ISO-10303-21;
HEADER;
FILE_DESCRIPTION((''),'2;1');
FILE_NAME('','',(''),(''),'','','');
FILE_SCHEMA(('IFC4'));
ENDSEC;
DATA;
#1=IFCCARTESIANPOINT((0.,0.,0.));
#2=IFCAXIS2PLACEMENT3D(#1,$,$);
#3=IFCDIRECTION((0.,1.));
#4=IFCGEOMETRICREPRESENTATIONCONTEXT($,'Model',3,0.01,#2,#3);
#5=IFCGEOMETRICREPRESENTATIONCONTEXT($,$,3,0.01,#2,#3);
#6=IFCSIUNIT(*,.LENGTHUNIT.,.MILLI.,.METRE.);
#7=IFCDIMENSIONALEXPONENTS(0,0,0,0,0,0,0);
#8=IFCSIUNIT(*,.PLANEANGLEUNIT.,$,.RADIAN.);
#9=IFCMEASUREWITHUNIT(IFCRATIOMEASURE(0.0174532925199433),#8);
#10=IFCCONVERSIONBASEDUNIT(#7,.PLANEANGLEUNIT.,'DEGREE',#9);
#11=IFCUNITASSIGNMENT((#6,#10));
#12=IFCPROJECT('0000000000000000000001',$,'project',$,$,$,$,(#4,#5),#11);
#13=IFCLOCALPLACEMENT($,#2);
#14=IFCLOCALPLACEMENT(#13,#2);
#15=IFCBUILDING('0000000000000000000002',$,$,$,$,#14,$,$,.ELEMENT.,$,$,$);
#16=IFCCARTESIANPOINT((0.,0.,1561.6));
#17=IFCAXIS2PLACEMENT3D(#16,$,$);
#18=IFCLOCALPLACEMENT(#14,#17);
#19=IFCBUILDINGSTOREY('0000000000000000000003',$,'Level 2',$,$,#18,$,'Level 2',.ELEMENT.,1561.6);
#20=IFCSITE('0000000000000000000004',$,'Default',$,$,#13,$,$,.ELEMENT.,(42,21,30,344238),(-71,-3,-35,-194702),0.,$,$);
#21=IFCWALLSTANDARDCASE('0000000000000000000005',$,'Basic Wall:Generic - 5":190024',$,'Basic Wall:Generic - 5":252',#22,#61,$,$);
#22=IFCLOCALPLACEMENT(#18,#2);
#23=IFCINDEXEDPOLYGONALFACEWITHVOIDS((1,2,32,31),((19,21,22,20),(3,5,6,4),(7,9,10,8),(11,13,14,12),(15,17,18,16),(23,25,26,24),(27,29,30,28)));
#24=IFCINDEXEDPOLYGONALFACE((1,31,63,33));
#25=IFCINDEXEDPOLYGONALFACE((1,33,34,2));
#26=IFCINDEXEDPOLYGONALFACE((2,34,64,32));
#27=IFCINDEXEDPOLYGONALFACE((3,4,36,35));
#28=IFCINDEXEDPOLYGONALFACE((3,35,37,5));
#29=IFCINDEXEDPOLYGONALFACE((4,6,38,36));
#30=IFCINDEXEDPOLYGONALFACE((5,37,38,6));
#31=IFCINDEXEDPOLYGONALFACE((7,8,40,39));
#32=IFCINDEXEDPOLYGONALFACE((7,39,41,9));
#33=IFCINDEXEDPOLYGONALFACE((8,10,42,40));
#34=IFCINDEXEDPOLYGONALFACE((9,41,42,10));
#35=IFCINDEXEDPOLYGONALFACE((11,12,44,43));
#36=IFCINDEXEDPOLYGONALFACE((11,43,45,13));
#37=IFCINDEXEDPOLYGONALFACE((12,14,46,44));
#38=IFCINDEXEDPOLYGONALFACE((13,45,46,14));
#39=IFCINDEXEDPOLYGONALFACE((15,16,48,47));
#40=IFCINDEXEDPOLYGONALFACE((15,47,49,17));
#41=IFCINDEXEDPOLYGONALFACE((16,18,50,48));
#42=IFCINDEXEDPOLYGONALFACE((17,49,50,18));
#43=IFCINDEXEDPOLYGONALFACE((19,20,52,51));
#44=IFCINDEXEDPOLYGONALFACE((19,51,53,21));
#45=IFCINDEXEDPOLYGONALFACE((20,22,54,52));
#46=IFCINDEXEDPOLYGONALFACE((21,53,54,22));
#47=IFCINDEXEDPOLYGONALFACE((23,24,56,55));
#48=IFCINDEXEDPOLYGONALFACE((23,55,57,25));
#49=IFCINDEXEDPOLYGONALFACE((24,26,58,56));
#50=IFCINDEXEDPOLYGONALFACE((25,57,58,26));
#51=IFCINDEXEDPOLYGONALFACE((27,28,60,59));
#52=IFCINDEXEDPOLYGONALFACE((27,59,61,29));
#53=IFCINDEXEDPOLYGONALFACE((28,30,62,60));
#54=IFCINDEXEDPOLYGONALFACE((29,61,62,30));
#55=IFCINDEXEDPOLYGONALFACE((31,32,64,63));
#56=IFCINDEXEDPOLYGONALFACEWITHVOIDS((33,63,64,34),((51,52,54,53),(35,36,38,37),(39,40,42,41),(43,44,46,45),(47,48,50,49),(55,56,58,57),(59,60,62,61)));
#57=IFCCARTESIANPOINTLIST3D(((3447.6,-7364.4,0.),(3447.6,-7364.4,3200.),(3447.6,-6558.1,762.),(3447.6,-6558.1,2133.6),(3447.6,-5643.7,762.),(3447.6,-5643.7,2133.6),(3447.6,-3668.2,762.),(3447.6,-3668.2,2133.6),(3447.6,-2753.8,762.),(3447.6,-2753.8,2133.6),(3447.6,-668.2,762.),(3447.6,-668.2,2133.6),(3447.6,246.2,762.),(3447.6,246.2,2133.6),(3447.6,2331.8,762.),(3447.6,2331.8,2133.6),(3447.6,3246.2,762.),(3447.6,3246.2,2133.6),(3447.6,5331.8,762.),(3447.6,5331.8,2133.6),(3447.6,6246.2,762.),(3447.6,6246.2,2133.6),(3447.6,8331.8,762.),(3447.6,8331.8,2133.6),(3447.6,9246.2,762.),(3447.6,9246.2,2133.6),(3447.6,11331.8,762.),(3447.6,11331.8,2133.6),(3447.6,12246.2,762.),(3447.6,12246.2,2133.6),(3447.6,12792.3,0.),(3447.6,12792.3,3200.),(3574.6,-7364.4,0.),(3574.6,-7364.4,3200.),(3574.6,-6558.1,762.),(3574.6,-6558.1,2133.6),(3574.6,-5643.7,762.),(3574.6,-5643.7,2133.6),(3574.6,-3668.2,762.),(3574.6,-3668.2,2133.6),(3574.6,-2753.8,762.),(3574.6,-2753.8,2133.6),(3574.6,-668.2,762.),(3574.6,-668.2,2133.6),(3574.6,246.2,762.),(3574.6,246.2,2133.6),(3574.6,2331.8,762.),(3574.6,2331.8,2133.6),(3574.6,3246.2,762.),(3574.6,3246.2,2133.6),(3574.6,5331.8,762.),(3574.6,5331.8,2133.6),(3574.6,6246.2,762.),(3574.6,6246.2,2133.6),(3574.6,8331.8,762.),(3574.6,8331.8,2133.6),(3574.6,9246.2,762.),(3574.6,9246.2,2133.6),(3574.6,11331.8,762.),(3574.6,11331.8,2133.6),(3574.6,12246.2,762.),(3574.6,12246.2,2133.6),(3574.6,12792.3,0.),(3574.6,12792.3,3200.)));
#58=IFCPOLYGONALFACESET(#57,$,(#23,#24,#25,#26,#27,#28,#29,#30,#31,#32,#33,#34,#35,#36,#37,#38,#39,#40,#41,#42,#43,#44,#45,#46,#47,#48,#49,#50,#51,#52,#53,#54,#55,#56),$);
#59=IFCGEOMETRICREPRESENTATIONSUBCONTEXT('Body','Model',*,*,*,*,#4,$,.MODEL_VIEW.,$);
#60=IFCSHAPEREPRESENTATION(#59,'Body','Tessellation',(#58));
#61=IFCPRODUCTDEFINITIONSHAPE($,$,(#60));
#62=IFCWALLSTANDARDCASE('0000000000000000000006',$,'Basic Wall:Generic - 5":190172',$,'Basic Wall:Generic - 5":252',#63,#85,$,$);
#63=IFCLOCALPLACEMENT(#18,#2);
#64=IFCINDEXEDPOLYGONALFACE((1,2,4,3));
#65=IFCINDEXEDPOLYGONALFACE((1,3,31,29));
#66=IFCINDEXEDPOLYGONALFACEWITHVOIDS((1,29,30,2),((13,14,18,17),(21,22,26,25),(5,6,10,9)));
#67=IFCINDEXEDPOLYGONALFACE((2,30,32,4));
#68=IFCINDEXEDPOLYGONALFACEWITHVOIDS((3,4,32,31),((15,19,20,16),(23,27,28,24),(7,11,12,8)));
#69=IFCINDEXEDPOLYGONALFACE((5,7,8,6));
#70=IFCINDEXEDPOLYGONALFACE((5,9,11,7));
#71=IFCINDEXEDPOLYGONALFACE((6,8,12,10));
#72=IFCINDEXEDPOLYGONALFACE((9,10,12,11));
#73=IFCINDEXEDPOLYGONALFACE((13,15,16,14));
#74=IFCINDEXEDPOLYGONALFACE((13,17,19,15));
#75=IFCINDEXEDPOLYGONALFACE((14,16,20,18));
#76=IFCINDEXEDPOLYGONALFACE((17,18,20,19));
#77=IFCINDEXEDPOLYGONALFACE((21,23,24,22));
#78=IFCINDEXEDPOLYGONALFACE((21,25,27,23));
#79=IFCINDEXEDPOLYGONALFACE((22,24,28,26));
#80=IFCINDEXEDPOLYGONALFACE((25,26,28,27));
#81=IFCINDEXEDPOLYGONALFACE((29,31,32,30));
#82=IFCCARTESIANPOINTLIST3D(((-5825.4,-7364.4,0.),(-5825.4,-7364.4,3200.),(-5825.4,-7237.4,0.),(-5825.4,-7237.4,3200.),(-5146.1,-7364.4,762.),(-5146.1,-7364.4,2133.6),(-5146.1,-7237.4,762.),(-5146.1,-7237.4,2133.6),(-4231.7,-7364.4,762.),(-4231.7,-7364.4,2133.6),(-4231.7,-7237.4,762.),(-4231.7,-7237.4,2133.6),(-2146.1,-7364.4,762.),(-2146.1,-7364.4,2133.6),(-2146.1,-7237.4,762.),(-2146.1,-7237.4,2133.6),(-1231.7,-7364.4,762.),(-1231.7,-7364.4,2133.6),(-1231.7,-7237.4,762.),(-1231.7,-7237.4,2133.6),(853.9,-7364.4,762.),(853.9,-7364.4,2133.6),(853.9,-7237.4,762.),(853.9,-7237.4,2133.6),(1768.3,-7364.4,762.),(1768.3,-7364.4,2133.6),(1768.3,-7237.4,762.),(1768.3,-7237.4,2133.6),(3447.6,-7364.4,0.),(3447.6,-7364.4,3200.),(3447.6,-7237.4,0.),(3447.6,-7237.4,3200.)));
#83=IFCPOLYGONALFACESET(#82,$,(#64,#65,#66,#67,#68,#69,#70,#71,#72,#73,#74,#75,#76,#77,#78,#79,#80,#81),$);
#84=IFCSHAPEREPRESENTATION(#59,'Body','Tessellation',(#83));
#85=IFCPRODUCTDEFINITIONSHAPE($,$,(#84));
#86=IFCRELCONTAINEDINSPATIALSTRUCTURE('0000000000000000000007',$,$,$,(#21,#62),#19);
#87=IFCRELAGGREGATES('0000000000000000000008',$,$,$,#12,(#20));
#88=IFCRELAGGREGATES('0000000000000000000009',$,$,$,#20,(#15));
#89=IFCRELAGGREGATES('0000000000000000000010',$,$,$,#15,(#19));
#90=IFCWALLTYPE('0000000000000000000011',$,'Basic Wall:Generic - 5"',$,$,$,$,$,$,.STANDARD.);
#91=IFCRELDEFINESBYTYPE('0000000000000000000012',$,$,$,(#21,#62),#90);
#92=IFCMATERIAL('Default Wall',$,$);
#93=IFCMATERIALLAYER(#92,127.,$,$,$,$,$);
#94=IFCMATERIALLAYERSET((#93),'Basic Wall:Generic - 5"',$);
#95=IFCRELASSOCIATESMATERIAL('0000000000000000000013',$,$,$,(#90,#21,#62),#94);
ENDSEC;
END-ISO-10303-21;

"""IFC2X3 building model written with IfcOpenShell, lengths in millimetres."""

from ifc_helpers import new_model, entity, si_unit, converted_unit, direction, frame, frame_2d, origin, place, context, subcontext, project, spatial, polyline, rectangle, extrude, clip, bounded_halfspace, material, layer, layer_set, layer_usage, type_object, element, save


model = new_model("IFC2X3")

# Units and contexts
model_context = context("Model", 3, precision=0.01, world=origin(), true_north=direction((0.0, 1.0)))
context_of_model = context(None, 3, precision=0.01, world=origin(), true_north=direction((0.0, 1.0)))
body_context = subcontext(model_context, "Body", "Model", "MODEL_VIEW")
ifc_project = project(units=[si_unit("LENGTHUNIT", "METRE", prefix="MILLI"), converted_unit("PLANEANGLEUNIT", "DEGREE", entity("IfcRatioMeasure", 0.0174532925199433), si_unit("PLANEANGLEUNIT", "RADIAN"), dimensions=[0, 0, 0, 0, 0, 0, 0])], contexts=[model_context, context_of_model])

# Site, building, storey
site_placement = place(None, origin())
site = spatial("IfcSite", under=ifc_project, at=site_placement, Name="Default", CompositionType="ELEMENT", RefLatitude=(42, 21, 30, 344238), RefLongitude=(-71, -3, -35, -194702), RefElevation=0.0)
building_placement = place(site_placement, origin())
building = spatial("IfcBuilding", under=site, at=building_placement, CompositionType="ELEMENT")
storey_placement = place(building_placement, frame((0.0, 0.0, 1561.6)))
storey = spatial("IfcBuildingStorey", under=building, at=storey_placement, Name="Level 2", LongName="Level 2", CompositionType="ELEMENT", Elevation=1561.6)

# Walls, openings
ifc_material_1 = material(Name="Default Wall")
ifc_layer_1 = layer(ifc_material_1, 127.0)
ifc_layer_set_1 = layer_set([ifc_layer_1], Name="Basic Wall:Generic - 5\"")
wall_type = type_object("IfcWallType", Name="Basic Wall:Generic - 5\"", PredefinedType="STANDARD", material=ifc_layer_set_1)
ifc_layer_usage_1 = layer_usage(ifc_layer_set_1, "AXIS2", "NEGATIVE", 63.5)
wall_1_placement = place(storey_placement, frame((3511.1, 12792.3, 0.0), z_axis=(0.0, 0.0, 1.0), x_axis=(0.0, -1.0, 0.0)))
wall_1 = element("IfcWallStandardCase", 1, at=wall_1_placement, inside=storey, type_object=wall_type, material=ifc_layer_usage_1, Name="Basic Wall:Generic - 5\":190024", ObjectType="Basic Wall:Generic - 5\":252", context=body_context, shape_type="Clipping", body=[
    clip(extrude(rectangle(XDim=20156.7, YDim=127.0, at=frame_2d((10078.4, 0.0), x_axis=(-1.0, 0.0))), origin(), (0.0, 0.0, 1.0), 3200.0), bounded_halfspace(frame((0.0, -63.5, 3200.0), z_axis=(0.0, 0.0, -1.0), x_axis=(0.0, 1.0, 0.0)), True, frame((0.0, -63.5, 3200.0)), polyline([(0.0, 0.0), (20029.7, 0.0), (20156.7, 0.0), (20156.7, 127.0), (0.0, 127.0), (0.0, 0.0)]))),
])
opening_1_placement = place(wall_1_placement, frame((1460.5, 63.5, 762.0)))
element("IfcOpeningElement", 2, at=opening_1_placement, cuts=wall_1, ObjectType="Opening", context=body_context, shape_type="SweptSolid", body=[
    extrude(rectangle(XDim=1371.6, YDim=914.4, at=frame_2d((685.8, 457.2), x_axis=(-1.0, 0.0))), frame((0.0, 0.0, 0.0), z_axis=(0.0, -1.0, 0.0), x_axis=(0.0, 0.0, 1.0)), (0.0, 0.0, 1.0), 127.0),
])
opening_2_placement = place(wall_1_placement, frame((4460.5, 63.5, 762.0)))
element("IfcOpeningElement", 3, at=opening_2_placement, cuts=wall_1, ObjectType="Opening", context=body_context, shape_type="SweptSolid", body=[
    extrude(rectangle(XDim=1371.6, YDim=914.4, at=frame_2d((685.8, 457.2), x_axis=(-1.0, 0.0))), frame((0.0, 0.0, 0.0), z_axis=(0.0, -1.0, 0.0), x_axis=(0.0, 0.0, 1.0)), (0.0, 0.0, 1.0), 127.0),
])
opening_3_placement = place(wall_1_placement, frame((7460.5, 63.5, 762.0)))
element("IfcOpeningElement", 4, at=opening_3_placement, cuts=wall_1, ObjectType="Opening", context=body_context, shape_type="SweptSolid", body=[
    extrude(rectangle(XDim=1371.6, YDim=914.4, at=frame_2d((685.8, 457.2), x_axis=(-1.0, 0.0))), frame((0.0, 0.0, 0.0), z_axis=(0.0, -1.0, 0.0), x_axis=(0.0, 0.0, 1.0)), (0.0, 0.0, 1.0), 127.0),
])
opening_4_placement = place(wall_1_placement, frame((10460.5, 63.5, 762.0)))
element("IfcOpeningElement", 5, at=opening_4_placement, cuts=wall_1, ObjectType="Opening", context=body_context, shape_type="SweptSolid", body=[
    extrude(rectangle(XDim=1371.6, YDim=914.4, at=frame_2d((685.8, 457.2), x_axis=(-1.0, 0.0))), frame((0.0, 0.0, 0.0), z_axis=(0.0, -1.0, 0.0), x_axis=(0.0, 0.0, 1.0)), (0.0, 0.0, 1.0), 127.0),
])
opening_5_placement = place(wall_1_placement, frame((13460.5, 63.5, 762.0)))
element("IfcOpeningElement", 6, at=opening_5_placement, cuts=wall_1, ObjectType="Opening", context=body_context, shape_type="SweptSolid", body=[
    extrude(rectangle(XDim=1371.6, YDim=914.4, at=frame_2d((685.8, 457.2), x_axis=(-1.0, 0.0))), frame((0.0, 0.0, 0.0), z_axis=(0.0, -1.0, 0.0), x_axis=(0.0, 0.0, 1.0)), (0.0, 0.0, 1.0), 127.0),
])
opening_6_placement = place(wall_1_placement, frame((16460.5, 63.5, 762.0)))
element("IfcOpeningElement", 7, at=opening_6_placement, cuts=wall_1, ObjectType="Opening", context=body_context, shape_type="SweptSolid", body=[
    extrude(rectangle(XDim=1371.6, YDim=914.4, at=frame_2d((685.8, 457.2), x_axis=(-1.0, 0.0))), frame((0.0, 0.0, 0.0), z_axis=(0.0, -1.0, 0.0), x_axis=(0.0, 0.0, 1.0)), (0.0, 0.0, 1.0), 127.0),
])
opening_7_placement = place(wall_1_placement, frame((19350.4, 63.5, 762.0)))
element("IfcOpeningElement", 8, at=opening_7_placement, cuts=wall_1, ObjectType="Opening", context=body_context, shape_type="SweptSolid", body=[
    extrude(rectangle(XDim=1371.6, YDim=914.4, at=frame_2d((685.8, 457.2), x_axis=(-1.0, 0.0))), frame((0.0, 0.0, 0.0), z_axis=(0.0, -1.0, 0.0), x_axis=(0.0, 0.0, 1.0)), (0.0, 0.0, 1.0), 127.0),
])
ifc_layer_usage_2 = layer_usage(ifc_layer_set_1, "AXIS2", "NEGATIVE", 63.5)
wall_2_placement = place(storey_placement, frame((3447.6, -7300.9, 0.0), z_axis=(0.0, 0.0, 1.0), x_axis=(-1.0, 0.0, 0.0)))
wall_2 = element("IfcWallStandardCase", 9, at=wall_2_placement, inside=storey, type_object=wall_type, material=ifc_layer_usage_2, Name="Basic Wall:Generic - 5\":190172", ObjectType="Basic Wall:Generic - 5\":252", context=body_context, shape_type="Clipping", body=[
    clip(extrude(rectangle(XDim=9273.0, YDim=127.0, at=frame_2d((4636.5, 0.0), x_axis=(-1.0, 0.0))), origin(), (0.0, 0.0, 1.0), 3200.0), bounded_halfspace(frame((0.0, -63.5, 3200.0), z_axis=(0.0, 0.0, -1.0), x_axis=(-1.0, 0.0, 0.0)), True, frame((0.0, -63.5, 3200.0)), polyline([(0.0, 0.0), (9273.0, 0.0), (9273.0, 127.0), (0.0, 127.0), (0.0, 0.0)]))),
])
opening_8_placement = place(wall_2_placement, frame((1679.3, -63.5, 762.0)))
element("IfcOpeningElement", 10, at=opening_8_placement, cuts=wall_2, ObjectType="Opening", context=body_context, shape_type="SweptSolid", body=[
    extrude(rectangle(XDim=1371.6, YDim=914.4, at=frame_2d((685.8, 457.2), x_axis=(-1.0, 0.0))), frame((0.0, 0.0, 0.0), z_axis=(0.0, 1.0, 0.0), x_axis=(0.0, 0.0, 1.0)), (0.0, 0.0, 1.0), 127.0),
])
opening_9_placement = place(wall_2_placement, frame((4679.3, -63.5, 762.0)))
element("IfcOpeningElement", 11, at=opening_9_placement, cuts=wall_2, ObjectType="Opening", context=body_context, shape_type="SweptSolid", body=[
    extrude(rectangle(XDim=1371.6, YDim=914.4, at=frame_2d((685.8, 457.2), x_axis=(-1.0, 0.0))), frame((0.0, 0.0, 0.0), z_axis=(0.0, 1.0, 0.0), x_axis=(0.0, 0.0, 1.0)), (0.0, 0.0, 1.0), 127.0),
])
opening_10_placement = place(wall_2_placement, frame((7679.3, -63.5, 762.0)))
element("IfcOpeningElement", 12, at=opening_10_placement, cuts=wall_2, ObjectType="Opening", context=body_context, shape_type="SweptSolid", body=[
    extrude(rectangle(XDim=1371.6, YDim=914.4, at=frame_2d((685.8, 457.2), x_axis=(-1.0, 0.0))), frame((0.0, 0.0, 0.0), z_axis=(0.0, 1.0, 0.0), x_axis=(0.0, 0.0, 1.0)), (0.0, 0.0, 1.0), 127.0),
])

save(model, "model.ifc")
